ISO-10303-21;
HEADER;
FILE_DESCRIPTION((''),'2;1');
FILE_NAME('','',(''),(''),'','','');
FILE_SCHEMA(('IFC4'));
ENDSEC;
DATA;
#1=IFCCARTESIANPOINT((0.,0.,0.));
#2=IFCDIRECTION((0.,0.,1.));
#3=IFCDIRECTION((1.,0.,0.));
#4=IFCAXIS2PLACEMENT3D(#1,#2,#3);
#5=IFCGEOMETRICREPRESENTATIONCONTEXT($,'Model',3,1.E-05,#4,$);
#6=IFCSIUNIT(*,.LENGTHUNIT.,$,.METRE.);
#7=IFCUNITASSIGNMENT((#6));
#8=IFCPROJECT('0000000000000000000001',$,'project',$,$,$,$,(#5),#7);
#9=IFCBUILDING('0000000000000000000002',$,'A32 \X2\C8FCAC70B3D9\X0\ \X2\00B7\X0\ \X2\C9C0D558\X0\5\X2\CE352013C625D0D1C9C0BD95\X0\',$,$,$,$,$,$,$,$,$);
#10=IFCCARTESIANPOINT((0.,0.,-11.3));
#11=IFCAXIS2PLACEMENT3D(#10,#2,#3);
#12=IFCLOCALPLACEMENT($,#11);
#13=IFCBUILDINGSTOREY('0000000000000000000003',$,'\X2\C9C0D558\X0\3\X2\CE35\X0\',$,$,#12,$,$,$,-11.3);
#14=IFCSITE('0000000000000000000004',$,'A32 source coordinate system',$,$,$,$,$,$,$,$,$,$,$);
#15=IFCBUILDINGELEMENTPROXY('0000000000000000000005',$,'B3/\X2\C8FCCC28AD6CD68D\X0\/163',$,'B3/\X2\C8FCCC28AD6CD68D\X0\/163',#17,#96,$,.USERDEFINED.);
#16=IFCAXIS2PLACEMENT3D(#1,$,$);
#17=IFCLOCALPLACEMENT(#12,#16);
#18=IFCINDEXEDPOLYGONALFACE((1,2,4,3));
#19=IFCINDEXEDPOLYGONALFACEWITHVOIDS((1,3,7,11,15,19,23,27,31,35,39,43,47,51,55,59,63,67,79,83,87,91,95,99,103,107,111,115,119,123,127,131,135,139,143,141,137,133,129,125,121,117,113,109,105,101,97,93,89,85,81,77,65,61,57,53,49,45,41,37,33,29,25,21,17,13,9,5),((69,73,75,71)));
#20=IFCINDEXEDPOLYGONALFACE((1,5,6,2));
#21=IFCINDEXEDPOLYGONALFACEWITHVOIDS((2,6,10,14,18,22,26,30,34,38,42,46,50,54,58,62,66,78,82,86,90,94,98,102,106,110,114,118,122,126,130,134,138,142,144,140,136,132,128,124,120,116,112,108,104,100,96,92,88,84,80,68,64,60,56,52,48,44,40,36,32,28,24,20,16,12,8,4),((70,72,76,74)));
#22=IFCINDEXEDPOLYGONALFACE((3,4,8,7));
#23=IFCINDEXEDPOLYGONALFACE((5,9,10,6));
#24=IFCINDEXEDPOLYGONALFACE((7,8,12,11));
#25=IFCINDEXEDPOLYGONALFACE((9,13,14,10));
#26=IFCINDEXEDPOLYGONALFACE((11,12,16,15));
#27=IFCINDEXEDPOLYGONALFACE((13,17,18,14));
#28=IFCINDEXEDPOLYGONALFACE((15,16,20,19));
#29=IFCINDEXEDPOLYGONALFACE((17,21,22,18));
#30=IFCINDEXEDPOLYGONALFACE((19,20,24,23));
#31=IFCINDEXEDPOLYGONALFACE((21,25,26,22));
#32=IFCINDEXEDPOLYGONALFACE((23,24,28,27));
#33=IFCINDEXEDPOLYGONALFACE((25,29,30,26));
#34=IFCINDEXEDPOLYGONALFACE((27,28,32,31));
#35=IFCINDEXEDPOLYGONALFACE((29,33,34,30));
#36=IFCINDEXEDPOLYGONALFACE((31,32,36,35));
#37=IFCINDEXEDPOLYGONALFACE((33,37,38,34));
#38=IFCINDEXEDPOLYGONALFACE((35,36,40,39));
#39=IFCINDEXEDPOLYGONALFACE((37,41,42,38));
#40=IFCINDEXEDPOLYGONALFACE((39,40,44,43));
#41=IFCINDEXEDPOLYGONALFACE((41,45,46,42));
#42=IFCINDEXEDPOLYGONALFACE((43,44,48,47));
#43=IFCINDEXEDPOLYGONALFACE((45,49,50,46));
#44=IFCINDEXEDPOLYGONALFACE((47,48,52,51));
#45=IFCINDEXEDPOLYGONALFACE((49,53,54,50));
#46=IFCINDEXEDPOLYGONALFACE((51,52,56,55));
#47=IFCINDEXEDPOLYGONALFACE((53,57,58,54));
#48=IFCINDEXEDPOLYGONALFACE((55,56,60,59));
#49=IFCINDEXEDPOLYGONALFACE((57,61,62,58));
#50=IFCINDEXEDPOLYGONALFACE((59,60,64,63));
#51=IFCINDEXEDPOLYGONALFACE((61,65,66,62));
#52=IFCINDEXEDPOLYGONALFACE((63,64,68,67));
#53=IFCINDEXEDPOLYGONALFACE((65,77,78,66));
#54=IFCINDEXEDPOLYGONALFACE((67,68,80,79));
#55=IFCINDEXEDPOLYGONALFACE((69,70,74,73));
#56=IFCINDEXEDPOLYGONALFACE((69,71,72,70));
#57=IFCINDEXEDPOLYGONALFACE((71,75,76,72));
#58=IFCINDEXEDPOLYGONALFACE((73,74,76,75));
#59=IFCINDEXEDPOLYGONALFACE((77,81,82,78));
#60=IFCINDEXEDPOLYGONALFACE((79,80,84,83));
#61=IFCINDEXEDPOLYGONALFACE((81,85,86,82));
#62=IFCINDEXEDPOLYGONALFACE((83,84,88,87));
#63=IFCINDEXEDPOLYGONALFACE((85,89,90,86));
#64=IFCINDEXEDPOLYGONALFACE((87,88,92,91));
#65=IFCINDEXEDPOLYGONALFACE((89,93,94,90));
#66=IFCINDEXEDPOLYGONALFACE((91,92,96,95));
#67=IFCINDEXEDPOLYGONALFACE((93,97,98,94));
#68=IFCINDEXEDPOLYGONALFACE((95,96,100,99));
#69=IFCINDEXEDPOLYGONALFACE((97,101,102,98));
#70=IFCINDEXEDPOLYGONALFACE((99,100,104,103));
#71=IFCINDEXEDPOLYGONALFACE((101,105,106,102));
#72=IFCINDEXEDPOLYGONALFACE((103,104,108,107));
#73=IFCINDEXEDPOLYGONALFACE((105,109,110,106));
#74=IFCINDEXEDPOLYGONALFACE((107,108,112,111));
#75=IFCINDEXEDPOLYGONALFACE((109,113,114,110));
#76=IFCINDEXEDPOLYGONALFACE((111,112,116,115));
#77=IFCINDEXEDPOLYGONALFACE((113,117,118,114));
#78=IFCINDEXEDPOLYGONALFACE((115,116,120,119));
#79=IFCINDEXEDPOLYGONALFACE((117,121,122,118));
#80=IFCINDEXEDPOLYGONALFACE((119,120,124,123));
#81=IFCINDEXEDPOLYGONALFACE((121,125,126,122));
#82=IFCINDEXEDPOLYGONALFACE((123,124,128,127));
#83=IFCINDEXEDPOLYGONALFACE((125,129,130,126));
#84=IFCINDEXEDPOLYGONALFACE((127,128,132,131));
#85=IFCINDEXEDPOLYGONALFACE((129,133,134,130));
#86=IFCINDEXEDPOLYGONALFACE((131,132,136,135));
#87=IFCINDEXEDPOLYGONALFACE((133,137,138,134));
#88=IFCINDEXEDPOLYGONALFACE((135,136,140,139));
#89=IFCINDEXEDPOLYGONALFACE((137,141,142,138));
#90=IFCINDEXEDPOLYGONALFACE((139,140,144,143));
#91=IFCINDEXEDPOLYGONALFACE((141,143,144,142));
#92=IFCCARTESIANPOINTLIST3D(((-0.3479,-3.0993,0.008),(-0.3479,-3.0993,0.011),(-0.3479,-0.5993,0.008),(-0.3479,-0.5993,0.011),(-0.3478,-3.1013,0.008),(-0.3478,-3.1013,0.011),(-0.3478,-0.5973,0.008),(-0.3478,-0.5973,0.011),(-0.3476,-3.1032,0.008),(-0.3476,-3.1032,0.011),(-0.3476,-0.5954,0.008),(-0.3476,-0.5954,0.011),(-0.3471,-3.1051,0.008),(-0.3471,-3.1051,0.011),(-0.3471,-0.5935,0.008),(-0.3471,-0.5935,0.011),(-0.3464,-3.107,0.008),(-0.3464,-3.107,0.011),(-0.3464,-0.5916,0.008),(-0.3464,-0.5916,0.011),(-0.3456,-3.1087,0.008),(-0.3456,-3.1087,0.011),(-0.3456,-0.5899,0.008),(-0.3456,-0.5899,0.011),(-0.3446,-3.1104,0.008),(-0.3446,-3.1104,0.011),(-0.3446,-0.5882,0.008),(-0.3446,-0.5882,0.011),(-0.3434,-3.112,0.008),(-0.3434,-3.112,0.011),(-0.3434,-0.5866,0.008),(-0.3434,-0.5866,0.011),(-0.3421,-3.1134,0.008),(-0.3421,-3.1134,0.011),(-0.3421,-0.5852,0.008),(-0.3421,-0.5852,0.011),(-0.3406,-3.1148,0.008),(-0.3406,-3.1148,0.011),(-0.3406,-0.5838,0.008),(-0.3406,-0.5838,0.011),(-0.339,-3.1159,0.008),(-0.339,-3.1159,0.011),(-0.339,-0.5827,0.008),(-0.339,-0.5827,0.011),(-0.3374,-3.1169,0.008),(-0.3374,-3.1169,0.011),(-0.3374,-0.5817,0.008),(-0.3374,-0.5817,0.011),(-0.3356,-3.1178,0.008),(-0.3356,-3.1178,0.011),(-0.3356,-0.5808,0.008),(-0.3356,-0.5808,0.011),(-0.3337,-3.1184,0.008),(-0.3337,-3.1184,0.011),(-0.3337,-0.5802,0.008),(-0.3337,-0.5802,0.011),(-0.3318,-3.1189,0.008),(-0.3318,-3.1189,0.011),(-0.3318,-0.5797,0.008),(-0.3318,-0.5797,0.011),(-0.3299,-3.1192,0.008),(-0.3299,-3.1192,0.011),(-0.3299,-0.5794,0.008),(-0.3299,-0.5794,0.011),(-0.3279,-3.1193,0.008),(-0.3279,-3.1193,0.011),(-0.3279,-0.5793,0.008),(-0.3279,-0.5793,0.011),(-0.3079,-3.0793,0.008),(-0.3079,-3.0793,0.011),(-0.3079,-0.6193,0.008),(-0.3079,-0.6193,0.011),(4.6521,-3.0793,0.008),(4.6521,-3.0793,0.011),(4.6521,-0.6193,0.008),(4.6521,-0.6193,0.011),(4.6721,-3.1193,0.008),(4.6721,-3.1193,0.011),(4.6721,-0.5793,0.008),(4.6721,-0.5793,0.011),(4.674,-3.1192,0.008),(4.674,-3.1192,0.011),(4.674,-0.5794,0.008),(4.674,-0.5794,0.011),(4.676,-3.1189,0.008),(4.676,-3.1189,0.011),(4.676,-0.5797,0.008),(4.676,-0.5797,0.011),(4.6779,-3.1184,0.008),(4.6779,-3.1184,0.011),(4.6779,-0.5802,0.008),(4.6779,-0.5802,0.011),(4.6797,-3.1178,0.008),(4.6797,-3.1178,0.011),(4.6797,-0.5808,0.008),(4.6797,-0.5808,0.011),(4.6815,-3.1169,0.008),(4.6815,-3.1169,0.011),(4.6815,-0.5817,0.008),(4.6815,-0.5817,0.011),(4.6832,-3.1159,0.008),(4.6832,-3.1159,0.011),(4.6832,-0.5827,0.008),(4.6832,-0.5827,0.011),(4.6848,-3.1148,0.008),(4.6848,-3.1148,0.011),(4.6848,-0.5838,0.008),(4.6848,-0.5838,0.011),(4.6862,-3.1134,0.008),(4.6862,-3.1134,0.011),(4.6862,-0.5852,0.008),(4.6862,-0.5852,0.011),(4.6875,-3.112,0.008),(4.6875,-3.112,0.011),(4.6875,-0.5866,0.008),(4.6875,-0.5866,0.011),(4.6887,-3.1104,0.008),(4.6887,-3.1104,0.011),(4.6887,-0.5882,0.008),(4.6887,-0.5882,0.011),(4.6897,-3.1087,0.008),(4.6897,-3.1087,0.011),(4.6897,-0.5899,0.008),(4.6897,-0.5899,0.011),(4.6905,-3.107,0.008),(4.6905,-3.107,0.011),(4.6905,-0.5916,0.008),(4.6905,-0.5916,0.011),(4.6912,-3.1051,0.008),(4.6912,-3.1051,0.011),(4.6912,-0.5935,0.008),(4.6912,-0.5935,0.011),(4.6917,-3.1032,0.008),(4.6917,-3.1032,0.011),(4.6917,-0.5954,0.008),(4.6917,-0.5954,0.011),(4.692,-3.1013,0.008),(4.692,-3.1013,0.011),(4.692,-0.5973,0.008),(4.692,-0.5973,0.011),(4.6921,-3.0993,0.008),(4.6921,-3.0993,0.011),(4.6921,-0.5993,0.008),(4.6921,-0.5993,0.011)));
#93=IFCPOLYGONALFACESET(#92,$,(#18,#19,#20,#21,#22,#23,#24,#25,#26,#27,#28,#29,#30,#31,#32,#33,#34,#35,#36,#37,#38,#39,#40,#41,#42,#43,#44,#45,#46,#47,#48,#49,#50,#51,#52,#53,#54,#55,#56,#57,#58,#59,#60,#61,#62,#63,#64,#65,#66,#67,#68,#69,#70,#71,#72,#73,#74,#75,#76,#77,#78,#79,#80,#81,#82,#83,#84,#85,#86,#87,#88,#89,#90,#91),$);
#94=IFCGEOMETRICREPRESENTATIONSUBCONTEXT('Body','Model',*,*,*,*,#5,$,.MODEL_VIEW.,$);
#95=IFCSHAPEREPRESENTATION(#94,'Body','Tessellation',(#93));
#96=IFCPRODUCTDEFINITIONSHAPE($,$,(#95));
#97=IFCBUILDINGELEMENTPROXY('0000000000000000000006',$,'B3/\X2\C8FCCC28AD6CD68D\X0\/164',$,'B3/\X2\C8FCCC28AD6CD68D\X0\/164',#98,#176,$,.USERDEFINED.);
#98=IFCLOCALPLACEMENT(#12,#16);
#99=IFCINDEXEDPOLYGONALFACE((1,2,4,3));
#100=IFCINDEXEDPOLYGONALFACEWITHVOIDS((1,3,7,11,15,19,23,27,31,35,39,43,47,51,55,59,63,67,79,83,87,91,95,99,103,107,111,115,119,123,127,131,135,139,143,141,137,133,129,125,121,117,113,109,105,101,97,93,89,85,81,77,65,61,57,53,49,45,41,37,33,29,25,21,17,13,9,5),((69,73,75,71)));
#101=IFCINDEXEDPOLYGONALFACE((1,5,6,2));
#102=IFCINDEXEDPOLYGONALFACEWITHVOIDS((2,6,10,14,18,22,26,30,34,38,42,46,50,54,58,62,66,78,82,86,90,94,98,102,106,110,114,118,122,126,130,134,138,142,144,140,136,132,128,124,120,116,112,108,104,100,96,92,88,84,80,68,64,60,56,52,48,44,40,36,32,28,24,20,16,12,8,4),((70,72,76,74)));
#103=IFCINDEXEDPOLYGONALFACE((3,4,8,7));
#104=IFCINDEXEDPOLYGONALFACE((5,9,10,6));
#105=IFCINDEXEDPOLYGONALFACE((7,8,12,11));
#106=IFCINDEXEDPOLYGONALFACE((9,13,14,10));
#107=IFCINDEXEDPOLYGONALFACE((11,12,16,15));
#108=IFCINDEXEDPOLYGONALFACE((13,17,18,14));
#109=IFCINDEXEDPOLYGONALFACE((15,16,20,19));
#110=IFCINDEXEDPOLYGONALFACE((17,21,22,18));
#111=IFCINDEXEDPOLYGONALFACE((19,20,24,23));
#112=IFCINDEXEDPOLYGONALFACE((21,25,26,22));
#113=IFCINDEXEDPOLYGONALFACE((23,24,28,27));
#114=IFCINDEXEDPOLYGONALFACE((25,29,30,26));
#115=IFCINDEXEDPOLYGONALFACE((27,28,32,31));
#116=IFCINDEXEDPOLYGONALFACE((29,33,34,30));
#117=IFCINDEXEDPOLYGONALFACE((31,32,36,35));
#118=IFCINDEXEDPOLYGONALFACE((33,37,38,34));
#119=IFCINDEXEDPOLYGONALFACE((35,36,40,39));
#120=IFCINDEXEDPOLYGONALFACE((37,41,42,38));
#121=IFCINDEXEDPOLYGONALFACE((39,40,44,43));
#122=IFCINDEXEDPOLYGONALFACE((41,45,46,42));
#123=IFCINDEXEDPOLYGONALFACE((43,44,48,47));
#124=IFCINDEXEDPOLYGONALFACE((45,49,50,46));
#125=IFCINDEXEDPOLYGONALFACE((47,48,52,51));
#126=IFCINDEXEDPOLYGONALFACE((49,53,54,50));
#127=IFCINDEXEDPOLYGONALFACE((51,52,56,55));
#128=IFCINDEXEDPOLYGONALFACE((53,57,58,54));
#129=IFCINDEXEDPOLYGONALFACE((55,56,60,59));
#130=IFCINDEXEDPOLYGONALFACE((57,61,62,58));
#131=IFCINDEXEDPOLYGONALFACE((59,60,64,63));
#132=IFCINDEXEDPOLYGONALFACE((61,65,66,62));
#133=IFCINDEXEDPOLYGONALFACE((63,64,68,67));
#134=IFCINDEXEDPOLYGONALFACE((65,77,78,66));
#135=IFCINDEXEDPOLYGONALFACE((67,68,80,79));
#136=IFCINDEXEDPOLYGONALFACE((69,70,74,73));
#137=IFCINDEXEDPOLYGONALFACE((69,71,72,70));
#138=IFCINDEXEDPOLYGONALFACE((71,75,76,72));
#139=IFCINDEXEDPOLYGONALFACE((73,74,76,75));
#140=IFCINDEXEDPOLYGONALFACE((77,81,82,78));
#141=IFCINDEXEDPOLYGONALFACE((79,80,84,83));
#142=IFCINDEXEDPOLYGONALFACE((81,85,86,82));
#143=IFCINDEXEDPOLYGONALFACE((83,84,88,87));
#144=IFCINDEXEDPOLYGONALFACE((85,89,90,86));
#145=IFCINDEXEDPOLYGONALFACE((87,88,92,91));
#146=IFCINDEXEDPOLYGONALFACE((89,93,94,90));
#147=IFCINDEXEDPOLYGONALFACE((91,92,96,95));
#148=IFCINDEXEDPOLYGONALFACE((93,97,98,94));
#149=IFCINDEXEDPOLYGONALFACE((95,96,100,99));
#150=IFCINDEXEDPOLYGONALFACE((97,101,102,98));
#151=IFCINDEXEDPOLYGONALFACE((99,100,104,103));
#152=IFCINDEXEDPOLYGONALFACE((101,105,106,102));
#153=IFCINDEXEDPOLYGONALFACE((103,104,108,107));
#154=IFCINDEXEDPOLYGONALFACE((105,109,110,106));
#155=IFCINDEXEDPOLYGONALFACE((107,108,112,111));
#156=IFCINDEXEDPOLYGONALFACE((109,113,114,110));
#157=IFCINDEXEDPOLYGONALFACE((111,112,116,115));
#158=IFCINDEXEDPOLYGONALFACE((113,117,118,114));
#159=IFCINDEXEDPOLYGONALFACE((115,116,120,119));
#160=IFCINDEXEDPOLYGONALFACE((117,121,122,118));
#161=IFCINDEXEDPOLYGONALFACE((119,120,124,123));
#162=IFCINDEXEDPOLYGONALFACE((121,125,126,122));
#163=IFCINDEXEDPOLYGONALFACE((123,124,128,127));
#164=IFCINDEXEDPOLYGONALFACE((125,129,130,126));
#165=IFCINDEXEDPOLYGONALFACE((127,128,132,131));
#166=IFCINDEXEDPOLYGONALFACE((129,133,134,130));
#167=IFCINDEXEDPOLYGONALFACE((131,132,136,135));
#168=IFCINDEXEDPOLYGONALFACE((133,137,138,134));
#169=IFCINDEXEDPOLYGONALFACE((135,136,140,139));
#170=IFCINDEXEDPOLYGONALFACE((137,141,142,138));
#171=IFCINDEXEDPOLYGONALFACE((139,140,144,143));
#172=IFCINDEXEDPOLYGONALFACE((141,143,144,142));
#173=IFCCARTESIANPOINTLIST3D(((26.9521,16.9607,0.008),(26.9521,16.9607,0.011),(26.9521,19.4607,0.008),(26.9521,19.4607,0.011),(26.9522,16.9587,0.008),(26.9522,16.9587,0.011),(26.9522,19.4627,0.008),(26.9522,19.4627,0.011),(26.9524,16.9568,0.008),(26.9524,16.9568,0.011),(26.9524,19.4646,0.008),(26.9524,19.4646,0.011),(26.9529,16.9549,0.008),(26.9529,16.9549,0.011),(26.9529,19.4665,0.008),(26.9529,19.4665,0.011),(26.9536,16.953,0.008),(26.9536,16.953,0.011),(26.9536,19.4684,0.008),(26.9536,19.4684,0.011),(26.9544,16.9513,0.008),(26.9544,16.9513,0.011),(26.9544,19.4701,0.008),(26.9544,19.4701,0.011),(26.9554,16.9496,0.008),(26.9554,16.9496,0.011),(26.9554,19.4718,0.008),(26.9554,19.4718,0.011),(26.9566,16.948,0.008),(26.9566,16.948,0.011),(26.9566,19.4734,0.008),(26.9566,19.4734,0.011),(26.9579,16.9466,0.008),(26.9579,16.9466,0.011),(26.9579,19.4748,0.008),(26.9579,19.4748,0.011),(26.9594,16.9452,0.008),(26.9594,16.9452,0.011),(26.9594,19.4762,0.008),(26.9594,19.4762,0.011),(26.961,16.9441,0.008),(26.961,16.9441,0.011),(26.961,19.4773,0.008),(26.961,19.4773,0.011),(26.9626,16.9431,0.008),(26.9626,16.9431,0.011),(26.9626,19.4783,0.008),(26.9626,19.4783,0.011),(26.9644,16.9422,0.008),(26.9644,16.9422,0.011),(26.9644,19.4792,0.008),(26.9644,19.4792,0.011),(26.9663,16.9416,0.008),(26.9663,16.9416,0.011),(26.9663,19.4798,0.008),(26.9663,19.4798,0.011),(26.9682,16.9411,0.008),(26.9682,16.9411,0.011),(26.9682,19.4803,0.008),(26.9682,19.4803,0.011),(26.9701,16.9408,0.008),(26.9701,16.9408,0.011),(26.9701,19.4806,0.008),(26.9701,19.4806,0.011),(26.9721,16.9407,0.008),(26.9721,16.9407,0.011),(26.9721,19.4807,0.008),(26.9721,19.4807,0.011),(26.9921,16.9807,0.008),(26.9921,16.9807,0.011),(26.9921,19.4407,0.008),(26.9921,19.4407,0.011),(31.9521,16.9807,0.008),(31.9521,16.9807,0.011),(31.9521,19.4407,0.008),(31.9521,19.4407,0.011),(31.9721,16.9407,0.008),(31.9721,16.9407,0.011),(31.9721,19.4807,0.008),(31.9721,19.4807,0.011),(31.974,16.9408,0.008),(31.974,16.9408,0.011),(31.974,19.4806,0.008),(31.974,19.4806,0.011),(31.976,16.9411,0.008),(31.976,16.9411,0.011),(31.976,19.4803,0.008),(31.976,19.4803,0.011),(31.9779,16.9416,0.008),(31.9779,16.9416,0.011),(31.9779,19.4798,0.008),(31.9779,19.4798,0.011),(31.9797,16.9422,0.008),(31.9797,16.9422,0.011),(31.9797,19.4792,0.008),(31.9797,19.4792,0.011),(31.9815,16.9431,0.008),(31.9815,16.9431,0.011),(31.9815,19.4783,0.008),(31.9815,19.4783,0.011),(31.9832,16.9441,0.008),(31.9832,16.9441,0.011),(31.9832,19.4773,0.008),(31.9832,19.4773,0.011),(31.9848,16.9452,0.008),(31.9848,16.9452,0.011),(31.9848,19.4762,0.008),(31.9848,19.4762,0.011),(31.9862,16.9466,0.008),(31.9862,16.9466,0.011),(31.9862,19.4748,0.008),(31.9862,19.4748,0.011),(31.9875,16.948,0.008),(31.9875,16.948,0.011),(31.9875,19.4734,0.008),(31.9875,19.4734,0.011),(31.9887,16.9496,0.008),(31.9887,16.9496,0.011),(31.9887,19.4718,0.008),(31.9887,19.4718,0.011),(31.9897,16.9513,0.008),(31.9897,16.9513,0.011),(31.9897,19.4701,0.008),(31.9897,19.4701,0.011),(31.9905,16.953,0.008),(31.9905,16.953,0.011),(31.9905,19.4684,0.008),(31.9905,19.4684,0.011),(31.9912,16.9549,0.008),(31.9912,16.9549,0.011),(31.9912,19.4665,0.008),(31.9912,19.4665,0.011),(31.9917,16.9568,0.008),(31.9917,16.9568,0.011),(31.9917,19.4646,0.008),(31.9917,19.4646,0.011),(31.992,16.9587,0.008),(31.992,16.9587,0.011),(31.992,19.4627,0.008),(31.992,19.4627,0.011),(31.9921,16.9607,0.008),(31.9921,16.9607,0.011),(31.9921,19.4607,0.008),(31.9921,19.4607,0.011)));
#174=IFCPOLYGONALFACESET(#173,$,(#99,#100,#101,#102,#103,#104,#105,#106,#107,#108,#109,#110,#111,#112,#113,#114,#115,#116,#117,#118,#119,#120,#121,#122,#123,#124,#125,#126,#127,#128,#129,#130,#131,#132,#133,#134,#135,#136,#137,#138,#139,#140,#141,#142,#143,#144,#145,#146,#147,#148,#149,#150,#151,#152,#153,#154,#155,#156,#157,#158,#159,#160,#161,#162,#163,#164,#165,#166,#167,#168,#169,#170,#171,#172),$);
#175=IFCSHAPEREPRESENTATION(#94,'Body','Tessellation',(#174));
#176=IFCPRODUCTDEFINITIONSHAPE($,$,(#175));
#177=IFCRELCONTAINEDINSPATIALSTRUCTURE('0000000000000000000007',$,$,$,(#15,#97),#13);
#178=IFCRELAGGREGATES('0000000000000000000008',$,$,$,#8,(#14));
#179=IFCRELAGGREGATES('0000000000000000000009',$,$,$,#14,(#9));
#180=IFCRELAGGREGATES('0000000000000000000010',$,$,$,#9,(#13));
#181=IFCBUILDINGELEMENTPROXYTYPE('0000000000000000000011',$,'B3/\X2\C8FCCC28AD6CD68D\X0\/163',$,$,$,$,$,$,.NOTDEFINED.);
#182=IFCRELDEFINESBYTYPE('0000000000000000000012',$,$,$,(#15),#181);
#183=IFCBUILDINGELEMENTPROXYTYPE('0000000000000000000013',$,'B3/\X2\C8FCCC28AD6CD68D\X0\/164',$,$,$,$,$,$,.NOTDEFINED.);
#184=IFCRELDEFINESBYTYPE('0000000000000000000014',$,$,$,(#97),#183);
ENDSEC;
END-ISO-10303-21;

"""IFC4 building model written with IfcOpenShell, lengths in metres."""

from ifc_helpers import new_model, si_unit, frame, origin, origin_with_axes, place, context, subcontext, project, spatial, polyline, outline, extrude, source, transform, mapped, type_object, type_shapes, element, save


model = new_model("IFC4")

# Units and contexts
model_context = context("Model", 3, precision=1e-05, world=origin_with_axes())
body_context = subcontext(model_context, "Body", "Model", "MODEL_VIEW")
ifc_project = project(units=[si_unit("LENGTHUNIT", "METRE")], contexts=[model_context])

# Site, building, storey
site = spatial("IfcSite", under=ifc_project, Name="A32 source coordinate system")
building = spatial("IfcBuilding", under=site, Name="A32 주거동 · 지하5층–옥탑지붕")
storey_placement = place(None, frame((0.0, 0.0, -11.3), z_axis=(0.0, 0.0, 1.0), x_axis=(1.0, 0.0, 0.0)))
storey = spatial("IfcBuildingStorey", under=building, at=storey_placement, Name="지하3층", Elevation=-11.3)

# Building element proxies
building_element_proxy_type_1 = type_object("IfcBuildingElementProxyType", Name="B3/주차구획/163", PredefinedType="NOTDEFINED")
shared_shape_1 = source(origin(), body_context, "Body", "SweptSolid", [
    extrude(outline(polyline([(-0.3279, -3.1193), (-0.3299, -3.1192), (-0.3318, -3.1189), (-0.3337, -3.1184), (-0.3356, -3.1178), (-0.3374, -3.1169), (-0.339, -3.1159), (-0.3406, -3.1148), (-0.3421, -3.1134), (-0.3434, -3.112), (-0.3446, -3.1104), (-0.3456, -3.1087), (-0.3464, -3.107), (-0.3471, -3.1051), (-0.3476, -3.1032), (-0.3478, -3.1013), (-0.3479, -3.0993), (-0.3479, -0.5993), (-0.3478, -0.5973), (-0.3476, -0.5954), (-0.3471, -0.5935), (-0.3464, -0.5916), (-0.3456, -0.5899), (-0.3446, -0.5882), (-0.3434, -0.5866), (-0.3421, -0.5852), (-0.3406, -0.5838), (-0.339, -0.5827), (-0.3374, -0.5817), (-0.3356, -0.5808), (-0.3337, -0.5802), (-0.3318, -0.5797), (-0.3299, -0.5794), (-0.3279, -0.5793), (4.6721, -0.5793), (4.674, -0.5794), (4.676, -0.5797), (4.6779, -0.5802), (4.6797, -0.5808), (4.6815, -0.5817), (4.6832, -0.5827), (4.6848, -0.5838), (4.6862, -0.5852), (4.6875, -0.5866), (4.6887, -0.5882), (4.6897, -0.5899), (4.6905, -0.5916), (4.6912, -0.5935), (4.6917, -0.5954), (4.692, -0.5973), (4.6921, -0.5993), (4.6921, -3.0993), (4.692, -3.1013), (4.6917, -3.1032), (4.6912, -3.1051), (4.6905, -3.107), (4.6897, -3.1087), (4.6887, -3.1104), (4.6875, -3.112), (4.6862, -3.1134), (4.6848, -3.1148), (4.6832, -3.1159), (4.6815, -3.1169), (4.6797, -3.1178), (4.6779, -3.1184), (4.676, -3.1189), (4.674, -3.1192), (4.6721, -3.1193), (-0.3279, -3.1193)]), holes=[polyline([(-0.3079, -3.0793), (4.6521, -3.0793), (4.6521, -0.6193), (-0.3079, -0.6193), (-0.3079, -3.0793)])]), frame((0.0, 0.0, 0.008)), (0.0, 0.0, 1.0), 0.003),
])
type_shapes(building_element_proxy_type_1, [shared_shape_1])
proxy_1_placement = place(storey_placement, origin_with_axes())
element("IfcBuildingElementProxy", 1, at=proxy_1_placement, inside=storey, type_object=building_element_proxy_type_1, Name="B3/주차구획/163", ObjectType="B3/주차구획/163", PredefinedType="USERDEFINED", context=body_context, shape_type="MappedRepresentation", body=[
    mapped(shared_shape_1, transform((0.0, 0.0, 0.0), scale=1.0)),
])
building_element_proxy_type_2 = type_object("IfcBuildingElementProxyType", Name="B3/주차구획/164", PredefinedType="NOTDEFINED")
shared_shape_2 = source(origin(), body_context, "Body", "SweptSolid", [
    extrude(outline(polyline([(26.9721, 16.9407), (26.9701, 16.9408), (26.9682, 16.9411), (26.9663, 16.9416), (26.9644, 16.9422), (26.9626, 16.9431), (26.961, 16.9441), (26.9594, 16.9452), (26.9579, 16.9466), (26.9566, 16.948), (26.9554, 16.9496), (26.9544, 16.9513), (26.9536, 16.953), (26.9529, 16.9549), (26.9524, 16.9568), (26.9522, 16.9587), (26.9521, 16.9607), (26.9521, 19.4607), (26.9522, 19.4627), (26.9524, 19.4646), (26.9529, 19.4665), (26.9536, 19.4684), (26.9544, 19.4701), (26.9554, 19.4718), (26.9566, 19.4734), (26.9579, 19.4748), (26.9594, 19.4762), (26.961, 19.4773), (26.9626, 19.4783), (26.9644, 19.4792), (26.9663, 19.4798), (26.9682, 19.4803), (26.9701, 19.4806), (26.9721, 19.4807), (31.9721, 19.4807), (31.974, 19.4806), (31.976, 19.4803), (31.9779, 19.4798), (31.9797, 19.4792), (31.9815, 19.4783), (31.9832, 19.4773), (31.9848, 19.4762), (31.9862, 19.4748), (31.9875, 19.4734), (31.9887, 19.4718), (31.9897, 19.4701), (31.9905, 19.4684), (31.9912, 19.4665), (31.9917, 19.4646), (31.992, 19.4627), (31.9921, 19.4607), (31.9921, 16.9607), (31.992, 16.9587), (31.9917, 16.9568), (31.9912, 16.9549), (31.9905, 16.953), (31.9897, 16.9513), (31.9887, 16.9496), (31.9875, 16.948), (31.9862, 16.9466), (31.9848, 16.9452), (31.9832, 16.9441), (31.9815, 16.9431), (31.9797, 16.9422), (31.9779, 16.9416), (31.976, 16.9411), (31.974, 16.9408), (31.9721, 16.9407), (26.9721, 16.9407)]), holes=[polyline([(26.9921, 16.9807), (31.9521, 16.9807), (31.9521, 19.4407), (26.9921, 19.4407), (26.9921, 16.9807)])]), frame((0.0, 0.0, 0.008)), (0.0, 0.0, 1.0), 0.003),
])
type_shapes(building_element_proxy_type_2, [shared_shape_2])
proxy_2_placement = place(storey_placement, origin_with_axes())
element("IfcBuildingElementProxy", 2, at=proxy_2_placement, inside=storey, type_object=building_element_proxy_type_2, Name="B3/주차구획/164", ObjectType="B3/주차구획/164", PredefinedType="USERDEFINED", context=body_context, shape_type="MappedRepresentation", body=[
    mapped(shared_shape_2, transform((0.0, 0.0, 0.0), scale=1.0)),
])

save(model, "model.ifc")
